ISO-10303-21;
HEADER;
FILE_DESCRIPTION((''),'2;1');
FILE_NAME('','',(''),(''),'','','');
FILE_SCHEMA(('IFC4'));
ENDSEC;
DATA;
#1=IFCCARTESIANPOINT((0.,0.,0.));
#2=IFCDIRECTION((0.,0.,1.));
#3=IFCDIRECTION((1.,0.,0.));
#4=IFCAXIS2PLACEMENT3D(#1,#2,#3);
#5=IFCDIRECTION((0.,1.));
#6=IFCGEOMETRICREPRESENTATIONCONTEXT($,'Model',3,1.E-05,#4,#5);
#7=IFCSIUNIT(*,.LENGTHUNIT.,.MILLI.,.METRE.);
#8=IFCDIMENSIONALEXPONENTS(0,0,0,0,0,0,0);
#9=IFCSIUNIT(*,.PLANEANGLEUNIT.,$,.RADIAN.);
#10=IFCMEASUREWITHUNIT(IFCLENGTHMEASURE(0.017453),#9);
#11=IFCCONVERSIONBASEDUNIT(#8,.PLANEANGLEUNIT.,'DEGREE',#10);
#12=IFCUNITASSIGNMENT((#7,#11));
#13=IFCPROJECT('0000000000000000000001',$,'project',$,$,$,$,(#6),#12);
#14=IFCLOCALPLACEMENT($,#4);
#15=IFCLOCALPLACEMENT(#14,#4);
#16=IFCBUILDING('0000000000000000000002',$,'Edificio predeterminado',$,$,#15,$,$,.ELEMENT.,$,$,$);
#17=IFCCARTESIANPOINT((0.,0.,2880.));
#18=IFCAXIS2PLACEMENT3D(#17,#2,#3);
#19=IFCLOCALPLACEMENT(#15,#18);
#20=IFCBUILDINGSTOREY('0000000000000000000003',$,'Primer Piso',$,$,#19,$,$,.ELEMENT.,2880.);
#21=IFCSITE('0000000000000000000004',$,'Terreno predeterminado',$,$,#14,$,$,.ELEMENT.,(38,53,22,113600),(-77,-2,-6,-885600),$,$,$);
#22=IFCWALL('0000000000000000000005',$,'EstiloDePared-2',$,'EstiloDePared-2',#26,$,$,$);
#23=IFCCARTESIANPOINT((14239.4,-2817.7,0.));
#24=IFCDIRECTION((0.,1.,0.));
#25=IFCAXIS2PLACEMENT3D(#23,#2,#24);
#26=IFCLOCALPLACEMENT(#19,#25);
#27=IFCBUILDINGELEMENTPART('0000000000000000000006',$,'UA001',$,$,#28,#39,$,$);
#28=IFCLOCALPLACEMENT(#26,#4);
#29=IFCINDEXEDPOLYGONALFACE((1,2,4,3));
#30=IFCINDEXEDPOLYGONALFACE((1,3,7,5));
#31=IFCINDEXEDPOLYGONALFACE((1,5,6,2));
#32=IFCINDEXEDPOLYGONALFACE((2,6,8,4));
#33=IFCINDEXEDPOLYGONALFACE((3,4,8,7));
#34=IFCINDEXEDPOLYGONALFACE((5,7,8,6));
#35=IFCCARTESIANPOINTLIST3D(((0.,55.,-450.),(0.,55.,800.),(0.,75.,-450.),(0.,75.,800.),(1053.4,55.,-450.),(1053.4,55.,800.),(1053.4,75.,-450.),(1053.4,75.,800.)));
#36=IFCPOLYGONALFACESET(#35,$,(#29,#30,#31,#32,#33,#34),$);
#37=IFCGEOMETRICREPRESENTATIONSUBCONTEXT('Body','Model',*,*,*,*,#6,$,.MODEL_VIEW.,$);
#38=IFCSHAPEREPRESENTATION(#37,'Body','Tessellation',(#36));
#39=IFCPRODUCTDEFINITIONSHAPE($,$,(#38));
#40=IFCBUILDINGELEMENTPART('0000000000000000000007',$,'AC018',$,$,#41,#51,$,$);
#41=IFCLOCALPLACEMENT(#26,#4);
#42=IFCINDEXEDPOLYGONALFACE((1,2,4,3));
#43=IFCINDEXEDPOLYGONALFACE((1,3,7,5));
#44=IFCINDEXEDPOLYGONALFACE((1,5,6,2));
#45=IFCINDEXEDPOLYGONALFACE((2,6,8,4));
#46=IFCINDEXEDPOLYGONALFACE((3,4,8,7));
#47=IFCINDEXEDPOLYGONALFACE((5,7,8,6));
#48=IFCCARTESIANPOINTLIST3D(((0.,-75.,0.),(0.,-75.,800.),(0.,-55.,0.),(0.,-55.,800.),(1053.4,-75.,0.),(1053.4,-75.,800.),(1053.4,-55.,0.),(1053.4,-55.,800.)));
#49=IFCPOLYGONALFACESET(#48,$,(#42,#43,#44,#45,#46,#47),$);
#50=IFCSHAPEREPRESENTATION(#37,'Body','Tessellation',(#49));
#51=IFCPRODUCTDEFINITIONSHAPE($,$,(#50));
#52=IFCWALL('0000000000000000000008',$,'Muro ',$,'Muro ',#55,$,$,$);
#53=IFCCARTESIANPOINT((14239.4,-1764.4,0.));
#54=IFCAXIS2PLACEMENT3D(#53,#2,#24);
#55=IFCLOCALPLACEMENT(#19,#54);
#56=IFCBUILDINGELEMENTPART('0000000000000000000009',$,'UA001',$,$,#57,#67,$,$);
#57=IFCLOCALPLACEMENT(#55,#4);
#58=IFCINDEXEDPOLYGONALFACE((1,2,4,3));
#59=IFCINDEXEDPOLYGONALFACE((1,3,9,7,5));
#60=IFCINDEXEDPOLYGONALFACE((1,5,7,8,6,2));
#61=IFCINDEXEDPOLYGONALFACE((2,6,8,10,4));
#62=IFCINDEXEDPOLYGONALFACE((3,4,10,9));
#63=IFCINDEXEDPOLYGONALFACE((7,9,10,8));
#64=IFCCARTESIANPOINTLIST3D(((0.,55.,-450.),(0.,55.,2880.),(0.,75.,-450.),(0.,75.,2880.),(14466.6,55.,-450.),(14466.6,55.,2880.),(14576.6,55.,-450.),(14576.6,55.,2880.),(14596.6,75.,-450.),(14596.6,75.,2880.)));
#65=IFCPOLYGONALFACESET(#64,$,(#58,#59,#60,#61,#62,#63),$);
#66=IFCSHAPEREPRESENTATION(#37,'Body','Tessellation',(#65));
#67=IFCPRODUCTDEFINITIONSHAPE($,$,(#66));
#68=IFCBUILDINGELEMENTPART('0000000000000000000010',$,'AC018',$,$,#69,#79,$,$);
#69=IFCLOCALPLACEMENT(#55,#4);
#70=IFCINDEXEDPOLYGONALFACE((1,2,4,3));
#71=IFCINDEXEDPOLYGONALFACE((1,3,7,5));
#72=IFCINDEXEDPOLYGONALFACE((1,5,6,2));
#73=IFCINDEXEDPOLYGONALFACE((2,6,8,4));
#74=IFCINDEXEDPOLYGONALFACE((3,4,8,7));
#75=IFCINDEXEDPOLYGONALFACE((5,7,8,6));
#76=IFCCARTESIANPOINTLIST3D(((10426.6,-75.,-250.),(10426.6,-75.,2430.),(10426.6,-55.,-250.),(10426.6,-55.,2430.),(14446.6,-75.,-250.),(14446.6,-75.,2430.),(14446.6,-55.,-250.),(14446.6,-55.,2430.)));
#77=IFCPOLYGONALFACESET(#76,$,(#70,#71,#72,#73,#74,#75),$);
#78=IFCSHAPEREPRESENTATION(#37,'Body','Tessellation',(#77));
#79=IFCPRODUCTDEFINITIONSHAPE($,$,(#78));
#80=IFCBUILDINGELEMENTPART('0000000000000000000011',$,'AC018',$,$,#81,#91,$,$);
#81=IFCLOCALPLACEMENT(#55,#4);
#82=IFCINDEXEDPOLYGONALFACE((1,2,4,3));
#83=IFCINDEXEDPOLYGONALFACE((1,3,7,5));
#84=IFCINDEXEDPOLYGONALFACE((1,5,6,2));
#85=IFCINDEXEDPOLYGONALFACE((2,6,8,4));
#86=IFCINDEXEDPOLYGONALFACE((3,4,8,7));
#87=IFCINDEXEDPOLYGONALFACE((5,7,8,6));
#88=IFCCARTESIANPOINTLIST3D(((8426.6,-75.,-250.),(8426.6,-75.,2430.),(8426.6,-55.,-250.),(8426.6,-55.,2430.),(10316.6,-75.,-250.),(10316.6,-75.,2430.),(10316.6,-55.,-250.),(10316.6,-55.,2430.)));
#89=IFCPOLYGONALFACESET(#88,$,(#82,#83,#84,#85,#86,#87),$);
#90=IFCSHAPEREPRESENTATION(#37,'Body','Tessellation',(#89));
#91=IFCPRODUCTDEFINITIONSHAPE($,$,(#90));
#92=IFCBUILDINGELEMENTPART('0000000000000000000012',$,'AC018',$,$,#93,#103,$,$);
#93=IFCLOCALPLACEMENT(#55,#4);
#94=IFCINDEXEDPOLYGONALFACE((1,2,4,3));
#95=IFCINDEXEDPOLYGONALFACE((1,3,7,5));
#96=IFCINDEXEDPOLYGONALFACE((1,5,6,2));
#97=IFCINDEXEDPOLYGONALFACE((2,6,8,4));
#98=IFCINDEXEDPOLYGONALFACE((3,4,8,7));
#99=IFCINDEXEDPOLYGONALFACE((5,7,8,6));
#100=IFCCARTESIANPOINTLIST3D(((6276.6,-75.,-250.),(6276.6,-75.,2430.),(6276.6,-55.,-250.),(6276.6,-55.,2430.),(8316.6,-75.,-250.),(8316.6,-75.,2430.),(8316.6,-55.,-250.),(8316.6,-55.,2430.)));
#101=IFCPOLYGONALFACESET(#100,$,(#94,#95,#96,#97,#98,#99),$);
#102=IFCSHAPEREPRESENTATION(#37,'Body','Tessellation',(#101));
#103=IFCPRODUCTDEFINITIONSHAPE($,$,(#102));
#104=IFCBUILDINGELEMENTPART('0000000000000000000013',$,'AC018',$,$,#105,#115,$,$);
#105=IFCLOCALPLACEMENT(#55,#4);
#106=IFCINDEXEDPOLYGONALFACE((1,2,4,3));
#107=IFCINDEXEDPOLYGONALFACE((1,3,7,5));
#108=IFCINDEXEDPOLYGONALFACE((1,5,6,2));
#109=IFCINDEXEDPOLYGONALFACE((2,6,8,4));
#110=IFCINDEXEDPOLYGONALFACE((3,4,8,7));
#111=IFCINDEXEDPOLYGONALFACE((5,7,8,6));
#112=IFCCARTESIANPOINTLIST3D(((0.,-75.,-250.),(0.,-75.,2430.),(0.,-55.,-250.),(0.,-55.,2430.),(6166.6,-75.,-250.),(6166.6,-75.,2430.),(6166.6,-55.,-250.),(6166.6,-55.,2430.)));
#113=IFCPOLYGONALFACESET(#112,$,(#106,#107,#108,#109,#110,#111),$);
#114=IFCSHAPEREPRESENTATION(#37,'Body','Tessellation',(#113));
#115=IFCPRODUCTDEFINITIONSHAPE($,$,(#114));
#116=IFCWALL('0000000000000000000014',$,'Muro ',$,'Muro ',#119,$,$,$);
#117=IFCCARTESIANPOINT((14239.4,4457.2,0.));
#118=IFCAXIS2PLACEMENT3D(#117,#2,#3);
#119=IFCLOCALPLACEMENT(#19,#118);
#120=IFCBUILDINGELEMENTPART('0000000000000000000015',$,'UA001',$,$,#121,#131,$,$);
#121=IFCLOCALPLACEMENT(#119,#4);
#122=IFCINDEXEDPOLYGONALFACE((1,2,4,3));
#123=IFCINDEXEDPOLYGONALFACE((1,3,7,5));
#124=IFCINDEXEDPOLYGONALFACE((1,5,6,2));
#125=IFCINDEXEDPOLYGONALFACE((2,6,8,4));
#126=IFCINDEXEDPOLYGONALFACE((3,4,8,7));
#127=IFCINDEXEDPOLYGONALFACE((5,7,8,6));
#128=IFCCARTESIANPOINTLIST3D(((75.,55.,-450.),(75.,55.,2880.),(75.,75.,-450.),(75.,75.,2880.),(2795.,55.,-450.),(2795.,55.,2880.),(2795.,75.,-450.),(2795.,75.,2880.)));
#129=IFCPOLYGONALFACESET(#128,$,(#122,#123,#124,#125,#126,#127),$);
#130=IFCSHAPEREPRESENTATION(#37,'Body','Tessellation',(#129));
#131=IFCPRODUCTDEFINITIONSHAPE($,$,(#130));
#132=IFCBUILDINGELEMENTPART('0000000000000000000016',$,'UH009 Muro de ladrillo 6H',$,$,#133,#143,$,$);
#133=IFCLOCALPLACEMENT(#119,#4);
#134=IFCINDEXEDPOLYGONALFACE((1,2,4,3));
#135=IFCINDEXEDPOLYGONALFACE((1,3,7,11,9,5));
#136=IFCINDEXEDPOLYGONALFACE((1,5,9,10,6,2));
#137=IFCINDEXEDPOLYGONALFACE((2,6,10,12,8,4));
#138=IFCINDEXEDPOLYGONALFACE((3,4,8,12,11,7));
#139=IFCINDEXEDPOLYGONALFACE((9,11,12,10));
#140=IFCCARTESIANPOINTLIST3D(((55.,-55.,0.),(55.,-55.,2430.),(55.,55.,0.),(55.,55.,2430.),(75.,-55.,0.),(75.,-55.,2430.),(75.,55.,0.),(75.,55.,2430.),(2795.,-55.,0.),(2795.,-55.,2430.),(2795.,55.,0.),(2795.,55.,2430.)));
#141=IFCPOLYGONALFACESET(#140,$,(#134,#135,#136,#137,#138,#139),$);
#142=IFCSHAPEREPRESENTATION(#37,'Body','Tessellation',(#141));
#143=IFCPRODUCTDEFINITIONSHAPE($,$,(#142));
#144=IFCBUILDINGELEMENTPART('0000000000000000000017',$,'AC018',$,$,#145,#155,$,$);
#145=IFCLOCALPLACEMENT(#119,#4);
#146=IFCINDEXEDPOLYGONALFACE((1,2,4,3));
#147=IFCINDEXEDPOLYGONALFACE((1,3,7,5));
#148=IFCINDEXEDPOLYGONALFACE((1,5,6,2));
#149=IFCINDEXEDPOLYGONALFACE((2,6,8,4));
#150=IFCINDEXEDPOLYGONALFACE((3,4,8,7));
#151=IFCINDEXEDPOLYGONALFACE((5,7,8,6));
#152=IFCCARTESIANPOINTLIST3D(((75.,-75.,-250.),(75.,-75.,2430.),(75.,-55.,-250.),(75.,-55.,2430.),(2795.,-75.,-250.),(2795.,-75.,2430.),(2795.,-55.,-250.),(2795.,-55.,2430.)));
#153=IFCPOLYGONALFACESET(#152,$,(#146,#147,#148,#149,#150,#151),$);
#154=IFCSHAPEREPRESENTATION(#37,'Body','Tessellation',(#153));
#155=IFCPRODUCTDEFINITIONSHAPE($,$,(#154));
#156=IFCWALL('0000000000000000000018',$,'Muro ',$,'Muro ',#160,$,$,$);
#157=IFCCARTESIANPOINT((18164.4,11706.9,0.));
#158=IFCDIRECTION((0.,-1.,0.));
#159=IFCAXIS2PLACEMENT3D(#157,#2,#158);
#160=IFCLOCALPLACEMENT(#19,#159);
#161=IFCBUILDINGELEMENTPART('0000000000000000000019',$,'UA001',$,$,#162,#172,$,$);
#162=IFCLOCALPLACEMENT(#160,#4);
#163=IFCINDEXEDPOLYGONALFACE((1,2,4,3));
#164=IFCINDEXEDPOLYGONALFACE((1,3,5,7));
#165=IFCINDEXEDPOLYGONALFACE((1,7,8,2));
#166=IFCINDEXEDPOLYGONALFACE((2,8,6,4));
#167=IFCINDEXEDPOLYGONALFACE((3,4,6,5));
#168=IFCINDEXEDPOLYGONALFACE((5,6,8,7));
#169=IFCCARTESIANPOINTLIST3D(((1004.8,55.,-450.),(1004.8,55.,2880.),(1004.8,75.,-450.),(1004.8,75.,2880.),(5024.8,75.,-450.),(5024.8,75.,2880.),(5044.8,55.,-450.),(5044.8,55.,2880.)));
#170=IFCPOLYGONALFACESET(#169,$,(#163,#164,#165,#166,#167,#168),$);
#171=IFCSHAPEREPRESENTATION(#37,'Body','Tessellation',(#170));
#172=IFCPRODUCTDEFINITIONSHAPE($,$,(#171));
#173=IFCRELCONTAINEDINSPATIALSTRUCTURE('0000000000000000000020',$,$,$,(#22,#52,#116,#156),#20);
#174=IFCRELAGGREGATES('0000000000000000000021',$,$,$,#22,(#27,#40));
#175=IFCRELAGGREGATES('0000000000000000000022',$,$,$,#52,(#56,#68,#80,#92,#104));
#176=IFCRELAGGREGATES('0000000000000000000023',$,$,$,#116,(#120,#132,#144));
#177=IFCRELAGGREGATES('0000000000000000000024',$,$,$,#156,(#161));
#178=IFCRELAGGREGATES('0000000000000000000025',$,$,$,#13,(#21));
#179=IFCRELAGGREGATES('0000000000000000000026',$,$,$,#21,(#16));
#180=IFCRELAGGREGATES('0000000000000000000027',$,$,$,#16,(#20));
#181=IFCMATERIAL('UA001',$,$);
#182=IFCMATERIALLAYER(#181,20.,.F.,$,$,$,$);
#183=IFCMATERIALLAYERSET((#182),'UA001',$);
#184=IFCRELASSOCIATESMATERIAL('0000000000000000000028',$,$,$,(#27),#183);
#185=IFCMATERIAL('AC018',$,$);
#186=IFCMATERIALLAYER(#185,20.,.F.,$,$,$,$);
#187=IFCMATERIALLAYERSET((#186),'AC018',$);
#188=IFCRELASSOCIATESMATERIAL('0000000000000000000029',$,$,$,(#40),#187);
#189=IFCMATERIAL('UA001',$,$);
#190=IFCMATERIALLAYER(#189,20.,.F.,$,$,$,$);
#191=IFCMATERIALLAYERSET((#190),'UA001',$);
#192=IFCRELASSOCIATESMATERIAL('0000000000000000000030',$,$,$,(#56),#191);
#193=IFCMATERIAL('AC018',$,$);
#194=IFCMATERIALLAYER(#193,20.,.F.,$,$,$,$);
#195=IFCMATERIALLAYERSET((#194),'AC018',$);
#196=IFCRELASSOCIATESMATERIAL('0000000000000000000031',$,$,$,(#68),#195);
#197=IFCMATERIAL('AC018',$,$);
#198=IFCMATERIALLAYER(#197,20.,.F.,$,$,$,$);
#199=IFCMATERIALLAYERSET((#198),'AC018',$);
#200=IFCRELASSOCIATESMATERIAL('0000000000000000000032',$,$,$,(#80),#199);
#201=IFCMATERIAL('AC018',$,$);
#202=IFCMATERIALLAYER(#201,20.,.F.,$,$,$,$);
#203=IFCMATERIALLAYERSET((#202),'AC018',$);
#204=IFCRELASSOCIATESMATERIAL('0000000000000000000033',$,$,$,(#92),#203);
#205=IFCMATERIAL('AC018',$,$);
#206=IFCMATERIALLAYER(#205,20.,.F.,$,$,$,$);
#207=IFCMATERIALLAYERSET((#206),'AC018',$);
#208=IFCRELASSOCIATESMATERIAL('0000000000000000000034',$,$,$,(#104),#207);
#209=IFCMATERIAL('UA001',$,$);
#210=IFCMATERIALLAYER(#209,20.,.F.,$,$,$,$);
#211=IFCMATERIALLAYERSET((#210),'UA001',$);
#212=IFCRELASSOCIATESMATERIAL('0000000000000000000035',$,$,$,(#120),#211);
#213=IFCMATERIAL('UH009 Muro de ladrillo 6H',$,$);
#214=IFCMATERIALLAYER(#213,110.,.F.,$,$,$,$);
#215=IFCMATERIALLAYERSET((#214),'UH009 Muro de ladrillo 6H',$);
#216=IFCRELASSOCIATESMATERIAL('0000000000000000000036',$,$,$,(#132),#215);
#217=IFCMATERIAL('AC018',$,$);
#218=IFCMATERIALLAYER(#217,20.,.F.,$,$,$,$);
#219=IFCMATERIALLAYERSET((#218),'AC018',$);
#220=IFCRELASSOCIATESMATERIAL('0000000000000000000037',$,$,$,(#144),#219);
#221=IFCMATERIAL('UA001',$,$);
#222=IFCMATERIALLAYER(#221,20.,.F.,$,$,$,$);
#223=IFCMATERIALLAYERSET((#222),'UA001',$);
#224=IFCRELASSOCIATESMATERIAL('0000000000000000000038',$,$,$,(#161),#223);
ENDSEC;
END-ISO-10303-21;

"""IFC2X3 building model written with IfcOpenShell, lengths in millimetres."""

from ifc_helpers import new_model, entity, si_unit, converted_unit, direction, frame, origin_with_axes, place, context, subcontext, project, spatial, polyline, outline, extrude, material, layer, layer_set, layer_usage, element, aggregate, save


model = new_model("IFC2X3")

# Units and contexts
model_context = context("Model", 3, precision=1e-05, world=origin_with_axes(), true_north=direction((0.0, 1.0)))
body_context = subcontext(model_context, "Body", "Model", "MODEL_VIEW")
ifc_project = project(units=[si_unit("LENGTHUNIT", "METRE", prefix="MILLI"), converted_unit("PLANEANGLEUNIT", "DEGREE", entity("IfcLengthMeasure", 0.017453), si_unit("PLANEANGLEUNIT", "RADIAN"), dimensions=[0, 0, 0, 0, 0, 0, 0])], contexts=[model_context])

# Site, building, storey
site_placement = place(None, origin_with_axes())
site = spatial("IfcSite", under=ifc_project, at=site_placement, Name="Terreno predeterminado", CompositionType="ELEMENT", RefLatitude=(38, 53, 22, 113600), RefLongitude=(-77, -2, -6, -885600))
building_placement = place(site_placement, origin_with_axes())
building = spatial("IfcBuilding", under=site, at=building_placement, Name="Edificio predeterminado", CompositionType="ELEMENT")
storey_placement = place(building_placement, frame((0.0, 0.0, 2880.0), z_axis=(0.0, 0.0, 1.0), x_axis=(1.0, 0.0, 0.0)))
storey = spatial("IfcBuildingStorey", under=building, at=storey_placement, Name="Primer Piso", CompositionType="ELEMENT", Elevation=2880.0)

# Walls, building element parts
wall_1_placement = place(storey_placement, frame((14239.4, -2817.7, 0.0), z_axis=(0.0, 0.0, 1.0), x_axis=(0.0, 1.0, 0.0)))
wall_1 = element("IfcWall", 1, at=wall_1_placement, inside=storey, Name="EstiloDePared-2", ObjectType="EstiloDePared-2")
ifc_material_1 = material(Name="UA001")
ifc_layer_1 = layer(ifc_material_1, 20.0, ventilated=False)
ifc_layer_set_1 = layer_set([ifc_layer_1], Name="UA001")
ifc_layer_usage_1 = layer_usage(ifc_layer_set_1, "AXIS2", "NEGATIVE", -75.0)
building_element_part_1_placement = place(wall_1_placement, origin_with_axes())
building_element_part_1 = element("IfcBuildingElementPart", 2, at=building_element_part_1_placement, material=ifc_layer_usage_1, Name="UA001", context=body_context, shape_type="SweptSolid", body=[
    extrude(outline(polyline([(1053.4, 75.0), (1053.4, 55.0), (0.0, 55.0), (0.0, 75.0), (1053.4, 75.0)])), frame((0.0, 0.0, -450.0), z_axis=(0.0, 0.0, 1.0), x_axis=(1.0, 0.0, 0.0)), (0.0, 0.0, 1.0), 1250.0),
])
ifc_material_2 = material(Name="AC018")
ifc_layer_2 = layer(ifc_material_2, 20.0, ventilated=False)
ifc_layer_set_2 = layer_set([ifc_layer_2], Name="AC018")
ifc_layer_usage_2 = layer_usage(ifc_layer_set_2, "AXIS2", "NEGATIVE", 55.0)
building_element_part_2_placement = place(wall_1_placement, origin_with_axes())
building_element_part_2 = element("IfcBuildingElementPart", 3, at=building_element_part_2_placement, material=ifc_layer_usage_2, Name="AC018", context=body_context, shape_type="SweptSolid", body=[
    extrude(outline(polyline([(1053.4, -55.0), (1053.4, -75.0), (0.0, -75.0), (0.0, -55.0), (1053.4, -55.0)])), origin_with_axes(), (0.0, 0.0, 1.0), 800.0),
])
aggregate(wall_1, [building_element_part_1, building_element_part_2])
wall_2_placement = place(storey_placement, frame((14239.4, -1764.4, 0.0), z_axis=(0.0, 0.0, 1.0), x_axis=(0.0, 1.0, 0.0)))
wall_2 = element("IfcWall", 4, at=wall_2_placement, inside=storey, Name="Muro ", ObjectType="Muro ")
ifc_material_3 = material(Name="UA001")
ifc_layer_3 = layer(ifc_material_3, 20.0, ventilated=False)
ifc_layer_set_3 = layer_set([ifc_layer_3], Name="UA001")
ifc_layer_usage_3 = layer_usage(ifc_layer_set_3, "AXIS2", "NEGATIVE", -75.0)
building_element_part_3_placement = place(wall_2_placement, origin_with_axes())
building_element_part_3 = element("IfcBuildingElementPart", 5, at=building_element_part_3_placement, material=ifc_layer_usage_3, Name="UA001", context=body_context, shape_type="SweptSolid", body=[
    extrude(outline(polyline([(14596.6, 75.0), (14576.6, 55.0), (14466.6, 55.0), (0.0, 55.0), (0.0, 75.0), (14596.6, 75.0)])), frame((0.0, 0.0, -450.0), z_axis=(0.0, 0.0, 1.0), x_axis=(1.0, 0.0, 0.0)), (0.0, 0.0, 1.0), 3330.0),
])
ifc_material_4 = material(Name="AC018")
ifc_layer_4 = layer(ifc_material_4, 20.0, ventilated=False)
ifc_layer_set_4 = layer_set([ifc_layer_4], Name="AC018")
ifc_layer_usage_4 = layer_usage(ifc_layer_set_4, "AXIS2", "NEGATIVE", 55.0)
building_element_part_4_placement = place(wall_2_placement, origin_with_axes())
building_element_part_4 = element("IfcBuildingElementPart", 6, at=building_element_part_4_placement, material=ifc_layer_usage_4, Name="AC018", context=body_context, shape_type="SweptSolid", body=[
    extrude(outline(polyline([(14446.6, -55.0), (14446.6, -75.0), (10426.6, -75.0), (10426.6, -55.0), (14446.6, -55.0)])), frame((0.0, 0.0, -250.0), z_axis=(0.0, 0.0, 1.0), x_axis=(1.0, 0.0, 0.0)), (0.0, 0.0, 1.0), 2680.0),
])
ifc_material_5 = material(Name="AC018")
ifc_layer_5 = layer(ifc_material_5, 20.0, ventilated=False)
ifc_layer_set_5 = layer_set([ifc_layer_5], Name="AC018")
ifc_layer_usage_5 = layer_usage(ifc_layer_set_5, "AXIS2", "NEGATIVE", 55.0)
building_element_part_5_placement = place(wall_2_placement, origin_with_axes())
building_element_part_5 = element("IfcBuildingElementPart", 7, at=building_element_part_5_placement, material=ifc_layer_usage_5, Name="AC018", context=body_context, shape_type="SweptSolid", body=[
    extrude(outline(polyline([(10316.6, -55.0), (10316.6, -75.0), (8426.6, -75.0), (8426.6, -55.0), (10316.6, -55.0)])), frame((0.0, 0.0, -250.0), z_axis=(0.0, 0.0, 1.0), x_axis=(1.0, 0.0, 0.0)), (0.0, 0.0, 1.0), 2680.0),
])
ifc_material_6 = material(Name="AC018")
ifc_layer_6 = layer(ifc_material_6, 20.0, ventilated=False)
ifc_layer_set_6 = layer_set([ifc_layer_6], Name="AC018")
ifc_layer_usage_6 = layer_usage(ifc_layer_set_6, "AXIS2", "NEGATIVE", 55.0)
building_element_part_6_placement = place(wall_2_placement, origin_with_axes())
building_element_part_6 = element("IfcBuildingElementPart", 8, at=building_element_part_6_placement, material=ifc_layer_usage_6, Name="AC018", context=body_context, shape_type="SweptSolid", body=[
    extrude(outline(polyline([(8316.6, -55.0), (8316.6, -75.0), (6276.6, -75.0), (6276.6, -55.0), (8316.6, -55.0)])), frame((0.0, 0.0, -250.0), z_axis=(0.0, 0.0, 1.0), x_axis=(1.0, 0.0, 0.0)), (0.0, 0.0, 1.0), 2680.0),
])
ifc_material_7 = material(Name="AC018")
ifc_layer_7 = layer(ifc_material_7, 20.0, ventilated=False)
ifc_layer_set_7 = layer_set([ifc_layer_7], Name="AC018")
ifc_layer_usage_7 = layer_usage(ifc_layer_set_7, "AXIS2", "NEGATIVE", 55.0)
building_element_part_7_placement = place(wall_2_placement, origin_with_axes())
building_element_part_7 = element("IfcBuildingElementPart", 9, at=building_element_part_7_placement, material=ifc_layer_usage_7, Name="AC018", context=body_context, shape_type="SweptSolid", body=[
    extrude(outline(polyline([(6166.6, -55.0), (6166.6, -75.0), (0.0, -75.0), (0.0, -55.0), (6166.6, -55.0)])), frame((0.0, 0.0, -250.0), z_axis=(0.0, 0.0, 1.0), x_axis=(1.0, 0.0, 0.0)), (0.0, 0.0, 1.0), 2680.0),
])
aggregate(wall_2, [building_element_part_3, building_element_part_4, building_element_part_5, building_element_part_6, building_element_part_7])
wall_3_placement = place(storey_placement, frame((14239.4, 4457.2, 0.0), z_axis=(0.0, 0.0, 1.0), x_axis=(1.0, 0.0, 0.0)))
wall_3 = element("IfcWall", 10, at=wall_3_placement, inside=storey, Name="Muro ", ObjectType="Muro ")
ifc_material_8 = material(Name="UA001")
ifc_layer_8 = layer(ifc_material_8, 20.0, ventilated=False)
ifc_layer_set_8 = layer_set([ifc_layer_8], Name="UA001")
ifc_layer_usage_8 = layer_usage(ifc_layer_set_8, "AXIS2", "NEGATIVE", -75.0)
building_element_part_8_placement = place(wall_3_placement, origin_with_axes())
building_element_part_8 = element("IfcBuildingElementPart", 11, at=building_element_part_8_placement, material=ifc_layer_usage_8, Name="UA001", context=body_context, shape_type="SweptSolid", body=[
    extrude(outline(polyline([(2795.0, 75.0), (2795.0, 55.0), (75.0, 55.0), (75.0, 75.0), (2795.0, 75.0)])), frame((0.0, 0.0, -450.0), z_axis=(0.0, 0.0, 1.0), x_axis=(1.0, 0.0, 0.0)), (0.0, 0.0, 1.0), 3330.0),
])
ifc_material_9 = material(Name="UH009 Muro de ladrillo 6H")
ifc_layer_9 = layer(ifc_material_9, 110.0, ventilated=False)
ifc_layer_set_9 = layer_set([ifc_layer_9], Name="UH009 Muro de ladrillo 6H")
ifc_layer_usage_9 = layer_usage(ifc_layer_set_9, "AXIS2", "NEGATIVE", -55.0)
building_element_part_9_placement = place(wall_3_placement, origin_with_axes())
building_element_part_9 = element("IfcBuildingElementPart", 12, at=building_element_part_9_placement, material=ifc_layer_usage_9, Name="UH009 Muro de ladrillo 6H", context=body_context, shape_type="SweptSolid", body=[
    extrude(outline(polyline([(2795.0, 55.0), (2795.0, -55.0), (75.0, -55.0), (55.0, -55.0), (55.0, 55.0), (75.0, 55.0), (2795.0, 55.0)])), origin_with_axes(), (0.0, 0.0, 1.0), 2430.0),
])
ifc_material_10 = material(Name="AC018")
ifc_layer_10 = layer(ifc_material_10, 20.0, ventilated=False)
ifc_layer_set_10 = layer_set([ifc_layer_10], Name="AC018")
ifc_layer_usage_10 = layer_usage(ifc_layer_set_10, "AXIS2", "NEGATIVE", 55.0)
building_element_part_10_placement = place(wall_3_placement, origin_with_axes())
building_element_part_10 = element("IfcBuildingElementPart", 13, at=building_element_part_10_placement, material=ifc_layer_usage_10, Name="AC018", context=body_context, shape_type="SweptSolid", body=[
    extrude(outline(polyline([(75.0, -55.0), (2795.0, -55.0), (2795.0, -75.0), (75.0, -75.0), (75.0, -55.0)])), frame((0.0, 0.0, -250.0), z_axis=(0.0, 0.0, 1.0), x_axis=(1.0, 0.0, 0.0)), (0.0, 0.0, 1.0), 2680.0),
])
aggregate(wall_3, [building_element_part_8, building_element_part_9, building_element_part_10])
wall_4_placement = place(storey_placement, frame((18164.4, 11706.9, 0.0), z_axis=(0.0, 0.0, 1.0), x_axis=(0.0, -1.0, 0.0)))
wall_4 = element("IfcWall", 14, at=wall_4_placement, inside=storey, Name="Muro ", ObjectType="Muro ")
ifc_material_11 = material(Name="UA001")
ifc_layer_11 = layer(ifc_material_11, 20.0, ventilated=False)
ifc_layer_set_11 = layer_set([ifc_layer_11], Name="UA001")
ifc_layer_usage_11 = layer_usage(ifc_layer_set_11, "AXIS2", "NEGATIVE", -75.0)
building_element_part_11_placement = place(wall_4_placement, origin_with_axes())
building_element_part_11 = element("IfcBuildingElementPart", 15, at=building_element_part_11_placement, material=ifc_layer_usage_11, Name="UA001", context=body_context, shape_type="SweptSolid", body=[
    extrude(outline(polyline([(5024.8, 75.0), (5044.8, 55.0), (1004.8, 55.0), (1004.8, 75.0), (5024.8, 75.0)])), frame((0.0, 0.0, -450.0), z_axis=(0.0, 0.0, 1.0), x_axis=(1.0, 0.0, 0.0)), (0.0, 0.0, 1.0), 3330.0),
])
aggregate(wall_4, [building_element_part_11])

save(model, "model.ifc")
